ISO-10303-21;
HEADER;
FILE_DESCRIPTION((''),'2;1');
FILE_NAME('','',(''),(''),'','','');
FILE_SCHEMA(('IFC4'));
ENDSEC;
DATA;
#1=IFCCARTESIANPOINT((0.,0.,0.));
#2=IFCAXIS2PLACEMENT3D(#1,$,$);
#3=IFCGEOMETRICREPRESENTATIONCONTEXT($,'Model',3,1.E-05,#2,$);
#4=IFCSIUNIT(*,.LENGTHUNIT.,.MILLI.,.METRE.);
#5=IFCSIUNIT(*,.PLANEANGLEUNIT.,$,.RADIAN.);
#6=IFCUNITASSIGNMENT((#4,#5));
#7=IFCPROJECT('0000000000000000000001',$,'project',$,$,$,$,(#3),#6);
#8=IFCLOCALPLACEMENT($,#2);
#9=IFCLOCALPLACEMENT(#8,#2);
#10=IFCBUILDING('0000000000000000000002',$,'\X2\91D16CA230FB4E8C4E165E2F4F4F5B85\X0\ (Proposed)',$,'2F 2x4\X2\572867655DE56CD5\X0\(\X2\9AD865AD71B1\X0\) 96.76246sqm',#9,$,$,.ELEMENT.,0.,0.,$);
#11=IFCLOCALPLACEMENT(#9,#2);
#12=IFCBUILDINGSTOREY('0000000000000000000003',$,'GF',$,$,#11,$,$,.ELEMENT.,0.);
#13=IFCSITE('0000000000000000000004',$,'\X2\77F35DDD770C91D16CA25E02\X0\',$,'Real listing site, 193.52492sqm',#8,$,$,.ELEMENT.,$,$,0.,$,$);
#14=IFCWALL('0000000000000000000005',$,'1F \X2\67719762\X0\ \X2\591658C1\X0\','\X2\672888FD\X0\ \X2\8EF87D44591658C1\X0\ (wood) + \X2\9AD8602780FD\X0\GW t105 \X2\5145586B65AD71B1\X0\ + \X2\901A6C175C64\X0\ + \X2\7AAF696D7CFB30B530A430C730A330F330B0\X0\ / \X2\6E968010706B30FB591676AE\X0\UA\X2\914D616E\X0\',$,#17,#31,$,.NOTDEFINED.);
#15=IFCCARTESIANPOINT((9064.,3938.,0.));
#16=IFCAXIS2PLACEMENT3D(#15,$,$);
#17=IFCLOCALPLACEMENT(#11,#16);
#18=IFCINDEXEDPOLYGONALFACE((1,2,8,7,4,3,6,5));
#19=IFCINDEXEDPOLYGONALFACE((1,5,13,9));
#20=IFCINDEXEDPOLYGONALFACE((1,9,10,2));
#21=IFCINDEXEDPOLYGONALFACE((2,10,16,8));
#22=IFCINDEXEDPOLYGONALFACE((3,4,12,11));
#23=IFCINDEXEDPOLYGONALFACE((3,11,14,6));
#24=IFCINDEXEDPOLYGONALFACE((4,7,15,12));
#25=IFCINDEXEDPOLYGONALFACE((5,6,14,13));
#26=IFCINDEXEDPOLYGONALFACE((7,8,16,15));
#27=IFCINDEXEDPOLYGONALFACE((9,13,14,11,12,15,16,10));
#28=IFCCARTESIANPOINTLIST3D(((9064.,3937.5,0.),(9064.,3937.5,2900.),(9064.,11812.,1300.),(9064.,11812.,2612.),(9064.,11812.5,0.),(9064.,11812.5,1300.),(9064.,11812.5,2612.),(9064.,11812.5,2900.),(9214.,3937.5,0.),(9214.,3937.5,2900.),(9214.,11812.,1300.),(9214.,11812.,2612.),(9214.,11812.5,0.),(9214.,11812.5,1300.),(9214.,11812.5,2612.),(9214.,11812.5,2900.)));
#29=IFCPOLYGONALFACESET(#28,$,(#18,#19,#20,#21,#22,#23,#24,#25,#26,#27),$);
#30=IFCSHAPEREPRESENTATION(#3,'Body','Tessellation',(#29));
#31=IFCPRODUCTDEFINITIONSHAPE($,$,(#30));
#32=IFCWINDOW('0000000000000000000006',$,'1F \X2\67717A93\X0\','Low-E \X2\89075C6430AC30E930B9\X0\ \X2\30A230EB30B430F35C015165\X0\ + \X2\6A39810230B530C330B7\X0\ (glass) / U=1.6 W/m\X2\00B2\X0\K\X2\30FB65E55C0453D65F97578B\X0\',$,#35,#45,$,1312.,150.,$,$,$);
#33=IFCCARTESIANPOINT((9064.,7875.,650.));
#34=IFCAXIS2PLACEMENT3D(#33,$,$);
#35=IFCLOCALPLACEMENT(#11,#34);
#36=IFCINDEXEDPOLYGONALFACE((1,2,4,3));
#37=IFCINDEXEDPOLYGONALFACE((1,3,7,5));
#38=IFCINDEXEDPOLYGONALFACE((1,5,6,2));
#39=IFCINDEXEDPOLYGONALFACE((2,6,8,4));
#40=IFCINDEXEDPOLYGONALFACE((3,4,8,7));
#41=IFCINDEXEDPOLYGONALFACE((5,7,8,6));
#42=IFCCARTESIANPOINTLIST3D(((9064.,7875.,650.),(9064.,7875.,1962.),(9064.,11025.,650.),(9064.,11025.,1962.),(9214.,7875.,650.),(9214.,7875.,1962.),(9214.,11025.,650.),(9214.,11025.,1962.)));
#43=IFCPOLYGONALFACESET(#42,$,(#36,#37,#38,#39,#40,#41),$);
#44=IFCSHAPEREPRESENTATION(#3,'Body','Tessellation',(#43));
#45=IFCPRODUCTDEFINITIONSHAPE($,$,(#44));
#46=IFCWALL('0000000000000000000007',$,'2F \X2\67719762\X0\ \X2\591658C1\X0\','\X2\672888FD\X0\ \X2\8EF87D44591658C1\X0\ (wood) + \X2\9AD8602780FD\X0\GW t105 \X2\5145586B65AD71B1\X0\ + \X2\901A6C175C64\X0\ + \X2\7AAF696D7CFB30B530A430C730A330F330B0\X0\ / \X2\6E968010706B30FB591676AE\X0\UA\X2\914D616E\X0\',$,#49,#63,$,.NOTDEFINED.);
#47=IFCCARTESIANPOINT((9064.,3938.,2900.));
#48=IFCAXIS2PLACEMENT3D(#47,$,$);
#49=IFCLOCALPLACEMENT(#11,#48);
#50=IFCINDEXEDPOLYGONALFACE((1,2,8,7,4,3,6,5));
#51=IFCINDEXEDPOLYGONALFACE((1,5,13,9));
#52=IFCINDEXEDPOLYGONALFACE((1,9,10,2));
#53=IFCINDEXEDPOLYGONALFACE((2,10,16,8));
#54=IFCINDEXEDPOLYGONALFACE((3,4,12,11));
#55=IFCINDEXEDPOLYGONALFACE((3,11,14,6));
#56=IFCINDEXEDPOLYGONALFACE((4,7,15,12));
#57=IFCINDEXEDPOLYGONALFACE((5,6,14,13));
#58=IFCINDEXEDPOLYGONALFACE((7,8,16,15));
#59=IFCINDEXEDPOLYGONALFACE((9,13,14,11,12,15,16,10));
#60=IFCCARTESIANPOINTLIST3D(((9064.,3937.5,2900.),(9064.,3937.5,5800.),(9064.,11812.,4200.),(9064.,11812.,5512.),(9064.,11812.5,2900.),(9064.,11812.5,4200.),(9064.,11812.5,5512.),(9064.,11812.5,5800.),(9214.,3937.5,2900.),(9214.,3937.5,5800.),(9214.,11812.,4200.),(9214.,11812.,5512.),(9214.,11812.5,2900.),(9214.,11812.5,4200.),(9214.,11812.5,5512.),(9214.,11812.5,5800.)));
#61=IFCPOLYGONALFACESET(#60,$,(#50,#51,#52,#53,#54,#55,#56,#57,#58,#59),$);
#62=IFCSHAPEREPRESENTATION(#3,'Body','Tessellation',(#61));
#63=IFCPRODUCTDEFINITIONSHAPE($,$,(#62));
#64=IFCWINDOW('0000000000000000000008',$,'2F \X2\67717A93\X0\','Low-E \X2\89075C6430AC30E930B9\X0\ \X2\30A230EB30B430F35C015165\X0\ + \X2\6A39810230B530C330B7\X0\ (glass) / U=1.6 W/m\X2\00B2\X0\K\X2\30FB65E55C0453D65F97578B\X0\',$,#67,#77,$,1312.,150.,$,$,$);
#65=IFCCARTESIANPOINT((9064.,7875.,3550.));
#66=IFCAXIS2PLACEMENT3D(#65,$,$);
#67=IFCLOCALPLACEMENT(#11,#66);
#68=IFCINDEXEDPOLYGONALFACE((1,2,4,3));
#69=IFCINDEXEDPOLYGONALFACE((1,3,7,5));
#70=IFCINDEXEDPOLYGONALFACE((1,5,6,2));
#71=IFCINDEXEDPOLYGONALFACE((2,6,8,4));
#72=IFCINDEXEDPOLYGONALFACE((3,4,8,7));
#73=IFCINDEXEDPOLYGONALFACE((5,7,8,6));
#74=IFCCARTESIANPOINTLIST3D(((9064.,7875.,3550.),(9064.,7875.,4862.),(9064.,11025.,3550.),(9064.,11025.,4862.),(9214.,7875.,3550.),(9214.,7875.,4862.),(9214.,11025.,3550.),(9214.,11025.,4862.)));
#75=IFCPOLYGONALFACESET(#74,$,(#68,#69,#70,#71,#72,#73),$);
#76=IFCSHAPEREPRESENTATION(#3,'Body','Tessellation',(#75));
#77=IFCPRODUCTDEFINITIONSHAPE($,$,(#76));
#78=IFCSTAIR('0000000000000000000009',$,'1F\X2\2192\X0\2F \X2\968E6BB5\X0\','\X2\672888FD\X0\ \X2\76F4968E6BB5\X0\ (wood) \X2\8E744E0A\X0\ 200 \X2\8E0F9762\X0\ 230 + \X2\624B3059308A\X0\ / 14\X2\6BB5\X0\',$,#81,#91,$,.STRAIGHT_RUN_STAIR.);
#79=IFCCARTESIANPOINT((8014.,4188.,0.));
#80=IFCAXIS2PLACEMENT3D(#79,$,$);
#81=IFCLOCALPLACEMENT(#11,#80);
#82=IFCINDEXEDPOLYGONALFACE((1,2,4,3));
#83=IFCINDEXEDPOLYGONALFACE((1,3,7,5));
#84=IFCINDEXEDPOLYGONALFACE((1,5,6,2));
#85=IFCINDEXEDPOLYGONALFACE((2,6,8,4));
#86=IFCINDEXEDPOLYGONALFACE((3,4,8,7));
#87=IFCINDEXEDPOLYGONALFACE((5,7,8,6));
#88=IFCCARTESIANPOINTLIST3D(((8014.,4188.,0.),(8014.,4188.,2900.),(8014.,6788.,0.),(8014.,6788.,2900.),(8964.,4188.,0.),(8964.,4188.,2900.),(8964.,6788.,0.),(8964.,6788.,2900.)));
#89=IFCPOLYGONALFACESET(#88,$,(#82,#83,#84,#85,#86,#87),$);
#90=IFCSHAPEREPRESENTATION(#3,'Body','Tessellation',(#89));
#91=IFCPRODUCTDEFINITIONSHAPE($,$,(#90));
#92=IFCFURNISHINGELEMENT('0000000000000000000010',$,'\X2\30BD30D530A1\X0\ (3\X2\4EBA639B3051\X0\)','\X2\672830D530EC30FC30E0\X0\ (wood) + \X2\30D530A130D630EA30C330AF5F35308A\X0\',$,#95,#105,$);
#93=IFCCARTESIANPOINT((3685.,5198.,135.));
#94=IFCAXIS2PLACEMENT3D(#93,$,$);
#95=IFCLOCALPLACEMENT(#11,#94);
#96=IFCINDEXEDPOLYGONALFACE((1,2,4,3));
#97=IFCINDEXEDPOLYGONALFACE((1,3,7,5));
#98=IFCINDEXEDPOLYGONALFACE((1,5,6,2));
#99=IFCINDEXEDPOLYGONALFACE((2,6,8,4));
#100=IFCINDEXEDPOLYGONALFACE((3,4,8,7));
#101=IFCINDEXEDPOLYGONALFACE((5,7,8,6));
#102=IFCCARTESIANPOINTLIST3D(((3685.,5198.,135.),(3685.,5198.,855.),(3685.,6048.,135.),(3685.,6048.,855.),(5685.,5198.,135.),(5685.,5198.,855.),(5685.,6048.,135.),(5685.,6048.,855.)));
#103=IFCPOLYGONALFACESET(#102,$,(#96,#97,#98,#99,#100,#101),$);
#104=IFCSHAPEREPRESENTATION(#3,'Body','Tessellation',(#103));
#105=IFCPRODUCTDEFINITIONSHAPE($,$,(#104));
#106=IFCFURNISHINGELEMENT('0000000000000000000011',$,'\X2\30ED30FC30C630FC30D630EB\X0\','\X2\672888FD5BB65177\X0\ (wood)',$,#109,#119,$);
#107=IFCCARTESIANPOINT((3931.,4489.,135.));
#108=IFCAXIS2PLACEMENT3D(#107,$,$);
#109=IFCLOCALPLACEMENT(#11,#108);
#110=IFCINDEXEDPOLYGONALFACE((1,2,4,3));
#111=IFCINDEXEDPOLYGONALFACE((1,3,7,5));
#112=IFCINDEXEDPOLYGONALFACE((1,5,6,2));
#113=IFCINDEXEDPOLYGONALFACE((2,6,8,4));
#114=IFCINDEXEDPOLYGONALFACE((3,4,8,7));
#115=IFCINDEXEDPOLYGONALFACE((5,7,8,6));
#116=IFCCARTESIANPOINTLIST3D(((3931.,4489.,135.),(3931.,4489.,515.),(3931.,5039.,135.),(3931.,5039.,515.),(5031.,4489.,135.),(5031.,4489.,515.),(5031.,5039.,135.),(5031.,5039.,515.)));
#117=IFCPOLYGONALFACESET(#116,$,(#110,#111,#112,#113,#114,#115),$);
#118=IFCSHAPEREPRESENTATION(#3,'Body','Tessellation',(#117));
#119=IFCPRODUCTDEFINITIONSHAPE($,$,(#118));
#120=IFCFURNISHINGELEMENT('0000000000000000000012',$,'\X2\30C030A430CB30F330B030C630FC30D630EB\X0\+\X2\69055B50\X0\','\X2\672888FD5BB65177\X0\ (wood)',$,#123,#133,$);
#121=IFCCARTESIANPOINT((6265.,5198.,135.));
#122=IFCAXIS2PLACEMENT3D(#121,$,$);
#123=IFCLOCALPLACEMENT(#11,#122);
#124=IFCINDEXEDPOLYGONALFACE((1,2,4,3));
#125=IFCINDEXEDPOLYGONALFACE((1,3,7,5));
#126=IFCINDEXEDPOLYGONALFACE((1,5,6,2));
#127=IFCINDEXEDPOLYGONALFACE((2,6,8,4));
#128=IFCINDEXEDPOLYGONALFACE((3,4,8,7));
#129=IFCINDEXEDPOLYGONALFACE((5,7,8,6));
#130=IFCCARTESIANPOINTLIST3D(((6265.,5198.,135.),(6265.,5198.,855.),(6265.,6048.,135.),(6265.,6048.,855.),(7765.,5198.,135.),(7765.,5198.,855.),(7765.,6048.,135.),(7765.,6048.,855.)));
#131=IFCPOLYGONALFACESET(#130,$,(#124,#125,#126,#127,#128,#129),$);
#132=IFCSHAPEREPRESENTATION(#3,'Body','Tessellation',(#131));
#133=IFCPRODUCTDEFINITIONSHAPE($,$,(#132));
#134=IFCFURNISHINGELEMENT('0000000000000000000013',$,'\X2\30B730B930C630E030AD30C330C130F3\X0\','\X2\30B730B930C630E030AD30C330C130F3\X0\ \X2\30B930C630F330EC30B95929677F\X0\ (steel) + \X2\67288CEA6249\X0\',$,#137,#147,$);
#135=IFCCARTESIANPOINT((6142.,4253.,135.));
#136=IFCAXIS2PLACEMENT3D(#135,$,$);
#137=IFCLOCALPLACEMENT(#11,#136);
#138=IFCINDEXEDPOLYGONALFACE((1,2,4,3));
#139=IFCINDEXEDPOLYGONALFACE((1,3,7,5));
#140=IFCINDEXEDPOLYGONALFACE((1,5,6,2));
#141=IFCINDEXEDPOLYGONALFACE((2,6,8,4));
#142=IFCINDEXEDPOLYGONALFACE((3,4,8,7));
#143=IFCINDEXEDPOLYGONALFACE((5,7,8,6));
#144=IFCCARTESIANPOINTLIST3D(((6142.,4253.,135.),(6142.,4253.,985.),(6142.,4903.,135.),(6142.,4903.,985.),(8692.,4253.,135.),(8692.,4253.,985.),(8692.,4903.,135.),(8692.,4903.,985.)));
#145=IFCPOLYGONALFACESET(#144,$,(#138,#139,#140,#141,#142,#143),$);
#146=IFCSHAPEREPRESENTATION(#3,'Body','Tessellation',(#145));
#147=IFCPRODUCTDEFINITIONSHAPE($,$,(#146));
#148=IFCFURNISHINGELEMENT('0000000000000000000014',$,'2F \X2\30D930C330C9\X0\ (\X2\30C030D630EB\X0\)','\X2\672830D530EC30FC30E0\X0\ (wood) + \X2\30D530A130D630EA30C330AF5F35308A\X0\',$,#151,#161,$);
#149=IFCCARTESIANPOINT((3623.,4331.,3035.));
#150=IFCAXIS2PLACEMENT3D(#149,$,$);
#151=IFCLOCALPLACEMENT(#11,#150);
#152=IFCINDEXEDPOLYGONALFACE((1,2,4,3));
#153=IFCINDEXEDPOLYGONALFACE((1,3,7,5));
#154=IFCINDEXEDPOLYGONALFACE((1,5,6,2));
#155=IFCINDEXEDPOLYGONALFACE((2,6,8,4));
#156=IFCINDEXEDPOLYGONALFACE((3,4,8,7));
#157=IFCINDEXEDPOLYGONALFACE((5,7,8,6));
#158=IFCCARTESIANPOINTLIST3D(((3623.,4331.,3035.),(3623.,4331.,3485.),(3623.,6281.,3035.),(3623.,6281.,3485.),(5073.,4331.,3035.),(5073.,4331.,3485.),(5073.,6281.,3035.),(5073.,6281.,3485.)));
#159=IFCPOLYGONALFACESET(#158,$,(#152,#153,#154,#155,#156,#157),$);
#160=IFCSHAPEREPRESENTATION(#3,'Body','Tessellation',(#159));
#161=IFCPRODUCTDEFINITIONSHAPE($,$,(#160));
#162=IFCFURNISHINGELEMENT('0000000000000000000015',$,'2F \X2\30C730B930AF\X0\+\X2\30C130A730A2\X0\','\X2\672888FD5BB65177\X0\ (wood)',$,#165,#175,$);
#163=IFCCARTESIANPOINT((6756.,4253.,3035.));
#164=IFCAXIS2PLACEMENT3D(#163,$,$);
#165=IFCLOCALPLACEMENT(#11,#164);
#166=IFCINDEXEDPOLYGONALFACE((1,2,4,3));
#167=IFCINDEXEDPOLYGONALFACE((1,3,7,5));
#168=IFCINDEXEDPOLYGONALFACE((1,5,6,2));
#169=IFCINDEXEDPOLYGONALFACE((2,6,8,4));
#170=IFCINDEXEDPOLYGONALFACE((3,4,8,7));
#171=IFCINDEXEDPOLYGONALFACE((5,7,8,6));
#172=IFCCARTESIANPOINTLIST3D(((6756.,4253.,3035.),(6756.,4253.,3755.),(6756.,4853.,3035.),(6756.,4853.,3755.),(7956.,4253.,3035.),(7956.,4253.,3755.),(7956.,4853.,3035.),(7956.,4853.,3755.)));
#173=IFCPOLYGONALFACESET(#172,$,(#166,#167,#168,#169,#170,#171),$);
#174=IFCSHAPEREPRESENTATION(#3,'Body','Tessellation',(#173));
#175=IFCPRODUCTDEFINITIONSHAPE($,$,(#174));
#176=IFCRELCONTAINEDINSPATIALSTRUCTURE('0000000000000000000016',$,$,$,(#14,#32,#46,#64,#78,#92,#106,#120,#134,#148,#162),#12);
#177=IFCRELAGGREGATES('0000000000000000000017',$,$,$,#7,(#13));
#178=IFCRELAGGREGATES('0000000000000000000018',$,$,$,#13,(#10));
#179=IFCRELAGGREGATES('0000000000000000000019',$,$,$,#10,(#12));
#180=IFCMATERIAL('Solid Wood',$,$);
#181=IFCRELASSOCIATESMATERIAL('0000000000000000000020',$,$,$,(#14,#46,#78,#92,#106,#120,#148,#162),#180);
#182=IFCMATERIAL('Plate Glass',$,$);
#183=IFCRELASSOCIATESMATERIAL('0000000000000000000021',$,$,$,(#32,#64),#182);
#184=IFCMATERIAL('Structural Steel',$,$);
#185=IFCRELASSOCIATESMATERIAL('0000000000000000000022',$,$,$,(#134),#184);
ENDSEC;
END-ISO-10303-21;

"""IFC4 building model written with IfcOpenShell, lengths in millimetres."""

from ifc_helpers import new_model, si_unit, frame, frame_2d, origin, place, context, project, spatial, rectangle, extrude, material, element, fill, save


model = new_model("IFC4")

# Units and contexts
model_context = context("Model", 3, precision=1e-05, world=origin())
ifc_project = project(units=[si_unit("LENGTHUNIT", "METRE", prefix="MILLI"), si_unit("PLANEANGLEUNIT", "RADIAN")], contexts=[model_context])

# Site, building, storey
site_placement = place(None, origin())
site = spatial("IfcSite", under=ifc_project, at=site_placement, Name="石川県金沢市", ObjectType="Real listing site, 193.52492sqm", CompositionType="ELEMENT", RefElevation=0.0)
building_placement = place(site_placement, origin())
building = spatial("IfcBuilding", under=site, at=building_placement, Name="金沢・二世帯住宅 (Proposed)", ObjectType="2F 2x4在来工法(高断熱) 96.76246sqm", CompositionType="ELEMENT", ElevationOfRefHeight=0.0, ElevationOfTerrain=0.0)
storey_placement = place(building_placement, origin())
storey = spatial("IfcBuildingStorey", under=building, at=storey_placement, Name="GF", CompositionType="ELEMENT", Elevation=0.0)

# Wall, opening, window
ifc_material_1 = material(Name="Solid Wood")
wall_1_placement = place(storey_placement, frame((9064.0, 3938.0, 0.0)))
wall_1 = element("IfcWall", 1, at=wall_1_placement, inside=storey, material=ifc_material_1, Name="1F 東面 外壁", Description="木製 軸組外壁 (wood) + 高性能GW t105 充填断熱 + 通気層 + 窯業系サイディング / 準耐火・外皮UA配慮", PredefinedType="NOTDEFINED", context=model_context, shape_type="SweptSolid", body=[
    extrude(rectangle(XDim=150.0, YDim=7875.0, at=frame_2d((75.0, 3937.0))), frame((9064.0, 3938.0, 0.0)), (0.0, 0.0, 1.0), 2900.0),
])
opening_1_placement = place(storey_placement, frame((9064.0, 7875.0, 650.0)))
opening_1 = element("IfcOpeningElement", 2, at=opening_1_placement, cuts=wall_1, PredefinedType="NOTDEFINED", context=model_context, shape_type="SweptSolid", body=[
    extrude(rectangle(XDim=150.0, YDim=3150.0, at=frame_2d((75.0, 1575.0))), frame((9064.0, 7875.0, 650.0)), (0.0, 0.0, 1.0), 1312.0),
])
ifc_material_2 = material(Name="Plate Glass")
window_1_placement = place(storey_placement, frame((9064.0, 7875.0, 650.0)))
window_1 = element("IfcWindow", 3, at=window_1_placement, inside=storey, material=ifc_material_2, Name="1F 東窓", Description="Low-E 複層ガラス アルゴン封入 + 樹脂サッシ (glass) / U=1.6 W/m²K・日射取得型", OverallHeight=1312.0, OverallWidth=150.0, context=model_context, shape_type="SweptSolid", body=[
    extrude(rectangle(XDim=150.0, YDim=3150.0, at=frame_2d((75.0, 1575.0))), frame((9064.0, 7875.0, 650.0)), (0.0, 0.0, 1.0), 1312.0),
])
fill(opening_1, window_1)

# Wall, opening, window
wall_2_placement = place(storey_placement, frame((9064.0, 3938.0, 2900.0)))
wall_2 = element("IfcWall", 4, at=wall_2_placement, inside=storey, material=ifc_material_1, Name="2F 東面 外壁", Description="木製 軸組外壁 (wood) + 高性能GW t105 充填断熱 + 通気層 + 窯業系サイディング / 準耐火・外皮UA配慮", PredefinedType="NOTDEFINED", context=model_context, shape_type="SweptSolid", body=[
    extrude(rectangle(XDim=150.0, YDim=7875.0, at=frame_2d((75.0, 3937.0))), frame((9064.0, 3938.0, 2900.0)), (0.0, 0.0, 1.0), 2900.0),
])
opening_2_placement = place(storey_placement, frame((9064.0, 7875.0, 3550.0)))
opening_2 = element("IfcOpeningElement", 5, at=opening_2_placement, cuts=wall_2, PredefinedType="NOTDEFINED", context=model_context, shape_type="SweptSolid", body=[
    extrude(rectangle(XDim=150.0, YDim=3150.0, at=frame_2d((75.0, 1575.0))), frame((9064.0, 7875.0, 3550.0)), (0.0, 0.0, 1.0), 1312.0),
])
window_2_placement = place(storey_placement, frame((9064.0, 7875.0, 3550.0)))
window_2 = element("IfcWindow", 6, at=window_2_placement, inside=storey, material=ifc_material_2, Name="2F 東窓", Description="Low-E 複層ガラス アルゴン封入 + 樹脂サッシ (glass) / U=1.6 W/m²K・日射取得型", OverallHeight=1312.0, OverallWidth=150.0, context=model_context, shape_type="SweptSolid", body=[
    extrude(rectangle(XDim=150.0, YDim=3150.0, at=frame_2d((75.0, 1575.0))), frame((9064.0, 7875.0, 3550.0)), (0.0, 0.0, 1.0), 1312.0),
])
fill(opening_2, window_2)

# Stair
stair_placement = place(storey_placement, frame((8014.0, 4188.0, 0.0)))
element("IfcStair", 7, at=stair_placement, inside=storey, material=ifc_material_1, Name="1F→2F 階段", Description="木製 直階段 (wood) 蹴上 200 踏面 230 + 手すり / 14段", PredefinedType="STRAIGHT_RUN_STAIR", context=model_context, shape_type="SweptSolid", body=[
    extrude(rectangle(XDim=950.0, YDim=2600.0, at=frame_2d((475.0, 1300.0))), frame((8014.0, 4188.0, 0.0)), (0.0, 0.0, 1.0), 2900.0),
])

# Furnishing elements
furnishing_1_placement = place(storey_placement, frame((3685.0, 5198.0, 135.0)))
element("IfcFurnishingElement", 8, at=furnishing_1_placement, inside=storey, material=ifc_material_1, Name="ソファ (3人掛け)", Description="木フレーム (wood) + ファブリック張り", context=model_context, shape_type="SweptSolid", body=[
    extrude(rectangle(XDim=2000.0, YDim=850.0, at=frame_2d((1000.0, 425.0))), frame((3685.0, 5198.0, 135.0)), (0.0, 0.0, 1.0), 720.0),
])
furnishing_2_placement = place(storey_placement, frame((3931.0, 4489.0, 135.0)))
element("IfcFurnishingElement", 9, at=furnishing_2_placement, inside=storey, material=ifc_material_1, Name="ローテーブル", Description="木製家具 (wood)", context=model_context, shape_type="SweptSolid", body=[
    extrude(rectangle(XDim=1100.0, YDim=550.0, at=frame_2d((550.0, 275.0))), frame((3931.0, 4489.0, 135.0)), (0.0, 0.0, 1.0), 380.0),
])
furnishing_3_placement = place(storey_placement, frame((6265.0, 5198.0, 135.0)))
element("IfcFurnishingElement", 10, at=furnishing_3_placement, inside=storey, material=ifc_material_1, Name="ダイニングテーブル+椅子", Description="木製家具 (wood)", context=model_context, shape_type="SweptSolid", body=[
    extrude(rectangle(XDim=1500.0, YDim=850.0, at=frame_2d((750.0, 425.0))), frame((6265.0, 5198.0, 135.0)), (0.0, 0.0, 1.0), 720.0),
])
ifc_material_3 = material(Name="Structural Steel")
furnishing_4_placement = place(storey_placement, frame((6142.0, 4253.0, 135.0)))
element("IfcFurnishingElement", 11, at=furnishing_4_placement, inside=storey, material=ifc_material_3, Name="システムキッチン", Description="システムキッチン ステンレス天板 (steel) + 木質扉", context=model_context, shape_type="SweptSolid", body=[
    extrude(rectangle(XDim=2550.0, YDim=650.0, at=frame_2d((1275.0, 325.0))), frame((6142.0, 4253.0, 135.0)), (0.0, 0.0, 1.0), 850.0),
])
furnishing_5_placement = place(storey_placement, frame((3623.0, 4331.0, 3035.0)))
element("IfcFurnishingElement", 12, at=furnishing_5_placement, inside=storey, material=ifc_material_1, Name="2F ベッド (ダブル)", Description="木フレーム (wood) + ファブリック張り", context=model_context, shape_type="SweptSolid", body=[
    extrude(rectangle(XDim=1450.0, YDim=1950.0, at=frame_2d((725.0, 975.0))), frame((3623.0, 4331.0, 3035.0)), (0.0, 0.0, 1.0), 450.0),
])
furnishing_6_placement = place(storey_placement, frame((6756.0, 4253.0, 3035.0)))
element("IfcFurnishingElement", 13, at=furnishing_6_placement, inside=storey, material=ifc_material_1, Name="2F デスク+チェア", Description="木製家具 (wood)", context=model_context, shape_type="SweptSolid", body=[
    extrude(rectangle(XDim=1200.0, YDim=600.0, at=frame_2d((600.0, 300.0))), frame((6756.0, 4253.0, 3035.0)), (0.0, 0.0, 1.0), 720.0),
])

save(model, "model.ifc")
